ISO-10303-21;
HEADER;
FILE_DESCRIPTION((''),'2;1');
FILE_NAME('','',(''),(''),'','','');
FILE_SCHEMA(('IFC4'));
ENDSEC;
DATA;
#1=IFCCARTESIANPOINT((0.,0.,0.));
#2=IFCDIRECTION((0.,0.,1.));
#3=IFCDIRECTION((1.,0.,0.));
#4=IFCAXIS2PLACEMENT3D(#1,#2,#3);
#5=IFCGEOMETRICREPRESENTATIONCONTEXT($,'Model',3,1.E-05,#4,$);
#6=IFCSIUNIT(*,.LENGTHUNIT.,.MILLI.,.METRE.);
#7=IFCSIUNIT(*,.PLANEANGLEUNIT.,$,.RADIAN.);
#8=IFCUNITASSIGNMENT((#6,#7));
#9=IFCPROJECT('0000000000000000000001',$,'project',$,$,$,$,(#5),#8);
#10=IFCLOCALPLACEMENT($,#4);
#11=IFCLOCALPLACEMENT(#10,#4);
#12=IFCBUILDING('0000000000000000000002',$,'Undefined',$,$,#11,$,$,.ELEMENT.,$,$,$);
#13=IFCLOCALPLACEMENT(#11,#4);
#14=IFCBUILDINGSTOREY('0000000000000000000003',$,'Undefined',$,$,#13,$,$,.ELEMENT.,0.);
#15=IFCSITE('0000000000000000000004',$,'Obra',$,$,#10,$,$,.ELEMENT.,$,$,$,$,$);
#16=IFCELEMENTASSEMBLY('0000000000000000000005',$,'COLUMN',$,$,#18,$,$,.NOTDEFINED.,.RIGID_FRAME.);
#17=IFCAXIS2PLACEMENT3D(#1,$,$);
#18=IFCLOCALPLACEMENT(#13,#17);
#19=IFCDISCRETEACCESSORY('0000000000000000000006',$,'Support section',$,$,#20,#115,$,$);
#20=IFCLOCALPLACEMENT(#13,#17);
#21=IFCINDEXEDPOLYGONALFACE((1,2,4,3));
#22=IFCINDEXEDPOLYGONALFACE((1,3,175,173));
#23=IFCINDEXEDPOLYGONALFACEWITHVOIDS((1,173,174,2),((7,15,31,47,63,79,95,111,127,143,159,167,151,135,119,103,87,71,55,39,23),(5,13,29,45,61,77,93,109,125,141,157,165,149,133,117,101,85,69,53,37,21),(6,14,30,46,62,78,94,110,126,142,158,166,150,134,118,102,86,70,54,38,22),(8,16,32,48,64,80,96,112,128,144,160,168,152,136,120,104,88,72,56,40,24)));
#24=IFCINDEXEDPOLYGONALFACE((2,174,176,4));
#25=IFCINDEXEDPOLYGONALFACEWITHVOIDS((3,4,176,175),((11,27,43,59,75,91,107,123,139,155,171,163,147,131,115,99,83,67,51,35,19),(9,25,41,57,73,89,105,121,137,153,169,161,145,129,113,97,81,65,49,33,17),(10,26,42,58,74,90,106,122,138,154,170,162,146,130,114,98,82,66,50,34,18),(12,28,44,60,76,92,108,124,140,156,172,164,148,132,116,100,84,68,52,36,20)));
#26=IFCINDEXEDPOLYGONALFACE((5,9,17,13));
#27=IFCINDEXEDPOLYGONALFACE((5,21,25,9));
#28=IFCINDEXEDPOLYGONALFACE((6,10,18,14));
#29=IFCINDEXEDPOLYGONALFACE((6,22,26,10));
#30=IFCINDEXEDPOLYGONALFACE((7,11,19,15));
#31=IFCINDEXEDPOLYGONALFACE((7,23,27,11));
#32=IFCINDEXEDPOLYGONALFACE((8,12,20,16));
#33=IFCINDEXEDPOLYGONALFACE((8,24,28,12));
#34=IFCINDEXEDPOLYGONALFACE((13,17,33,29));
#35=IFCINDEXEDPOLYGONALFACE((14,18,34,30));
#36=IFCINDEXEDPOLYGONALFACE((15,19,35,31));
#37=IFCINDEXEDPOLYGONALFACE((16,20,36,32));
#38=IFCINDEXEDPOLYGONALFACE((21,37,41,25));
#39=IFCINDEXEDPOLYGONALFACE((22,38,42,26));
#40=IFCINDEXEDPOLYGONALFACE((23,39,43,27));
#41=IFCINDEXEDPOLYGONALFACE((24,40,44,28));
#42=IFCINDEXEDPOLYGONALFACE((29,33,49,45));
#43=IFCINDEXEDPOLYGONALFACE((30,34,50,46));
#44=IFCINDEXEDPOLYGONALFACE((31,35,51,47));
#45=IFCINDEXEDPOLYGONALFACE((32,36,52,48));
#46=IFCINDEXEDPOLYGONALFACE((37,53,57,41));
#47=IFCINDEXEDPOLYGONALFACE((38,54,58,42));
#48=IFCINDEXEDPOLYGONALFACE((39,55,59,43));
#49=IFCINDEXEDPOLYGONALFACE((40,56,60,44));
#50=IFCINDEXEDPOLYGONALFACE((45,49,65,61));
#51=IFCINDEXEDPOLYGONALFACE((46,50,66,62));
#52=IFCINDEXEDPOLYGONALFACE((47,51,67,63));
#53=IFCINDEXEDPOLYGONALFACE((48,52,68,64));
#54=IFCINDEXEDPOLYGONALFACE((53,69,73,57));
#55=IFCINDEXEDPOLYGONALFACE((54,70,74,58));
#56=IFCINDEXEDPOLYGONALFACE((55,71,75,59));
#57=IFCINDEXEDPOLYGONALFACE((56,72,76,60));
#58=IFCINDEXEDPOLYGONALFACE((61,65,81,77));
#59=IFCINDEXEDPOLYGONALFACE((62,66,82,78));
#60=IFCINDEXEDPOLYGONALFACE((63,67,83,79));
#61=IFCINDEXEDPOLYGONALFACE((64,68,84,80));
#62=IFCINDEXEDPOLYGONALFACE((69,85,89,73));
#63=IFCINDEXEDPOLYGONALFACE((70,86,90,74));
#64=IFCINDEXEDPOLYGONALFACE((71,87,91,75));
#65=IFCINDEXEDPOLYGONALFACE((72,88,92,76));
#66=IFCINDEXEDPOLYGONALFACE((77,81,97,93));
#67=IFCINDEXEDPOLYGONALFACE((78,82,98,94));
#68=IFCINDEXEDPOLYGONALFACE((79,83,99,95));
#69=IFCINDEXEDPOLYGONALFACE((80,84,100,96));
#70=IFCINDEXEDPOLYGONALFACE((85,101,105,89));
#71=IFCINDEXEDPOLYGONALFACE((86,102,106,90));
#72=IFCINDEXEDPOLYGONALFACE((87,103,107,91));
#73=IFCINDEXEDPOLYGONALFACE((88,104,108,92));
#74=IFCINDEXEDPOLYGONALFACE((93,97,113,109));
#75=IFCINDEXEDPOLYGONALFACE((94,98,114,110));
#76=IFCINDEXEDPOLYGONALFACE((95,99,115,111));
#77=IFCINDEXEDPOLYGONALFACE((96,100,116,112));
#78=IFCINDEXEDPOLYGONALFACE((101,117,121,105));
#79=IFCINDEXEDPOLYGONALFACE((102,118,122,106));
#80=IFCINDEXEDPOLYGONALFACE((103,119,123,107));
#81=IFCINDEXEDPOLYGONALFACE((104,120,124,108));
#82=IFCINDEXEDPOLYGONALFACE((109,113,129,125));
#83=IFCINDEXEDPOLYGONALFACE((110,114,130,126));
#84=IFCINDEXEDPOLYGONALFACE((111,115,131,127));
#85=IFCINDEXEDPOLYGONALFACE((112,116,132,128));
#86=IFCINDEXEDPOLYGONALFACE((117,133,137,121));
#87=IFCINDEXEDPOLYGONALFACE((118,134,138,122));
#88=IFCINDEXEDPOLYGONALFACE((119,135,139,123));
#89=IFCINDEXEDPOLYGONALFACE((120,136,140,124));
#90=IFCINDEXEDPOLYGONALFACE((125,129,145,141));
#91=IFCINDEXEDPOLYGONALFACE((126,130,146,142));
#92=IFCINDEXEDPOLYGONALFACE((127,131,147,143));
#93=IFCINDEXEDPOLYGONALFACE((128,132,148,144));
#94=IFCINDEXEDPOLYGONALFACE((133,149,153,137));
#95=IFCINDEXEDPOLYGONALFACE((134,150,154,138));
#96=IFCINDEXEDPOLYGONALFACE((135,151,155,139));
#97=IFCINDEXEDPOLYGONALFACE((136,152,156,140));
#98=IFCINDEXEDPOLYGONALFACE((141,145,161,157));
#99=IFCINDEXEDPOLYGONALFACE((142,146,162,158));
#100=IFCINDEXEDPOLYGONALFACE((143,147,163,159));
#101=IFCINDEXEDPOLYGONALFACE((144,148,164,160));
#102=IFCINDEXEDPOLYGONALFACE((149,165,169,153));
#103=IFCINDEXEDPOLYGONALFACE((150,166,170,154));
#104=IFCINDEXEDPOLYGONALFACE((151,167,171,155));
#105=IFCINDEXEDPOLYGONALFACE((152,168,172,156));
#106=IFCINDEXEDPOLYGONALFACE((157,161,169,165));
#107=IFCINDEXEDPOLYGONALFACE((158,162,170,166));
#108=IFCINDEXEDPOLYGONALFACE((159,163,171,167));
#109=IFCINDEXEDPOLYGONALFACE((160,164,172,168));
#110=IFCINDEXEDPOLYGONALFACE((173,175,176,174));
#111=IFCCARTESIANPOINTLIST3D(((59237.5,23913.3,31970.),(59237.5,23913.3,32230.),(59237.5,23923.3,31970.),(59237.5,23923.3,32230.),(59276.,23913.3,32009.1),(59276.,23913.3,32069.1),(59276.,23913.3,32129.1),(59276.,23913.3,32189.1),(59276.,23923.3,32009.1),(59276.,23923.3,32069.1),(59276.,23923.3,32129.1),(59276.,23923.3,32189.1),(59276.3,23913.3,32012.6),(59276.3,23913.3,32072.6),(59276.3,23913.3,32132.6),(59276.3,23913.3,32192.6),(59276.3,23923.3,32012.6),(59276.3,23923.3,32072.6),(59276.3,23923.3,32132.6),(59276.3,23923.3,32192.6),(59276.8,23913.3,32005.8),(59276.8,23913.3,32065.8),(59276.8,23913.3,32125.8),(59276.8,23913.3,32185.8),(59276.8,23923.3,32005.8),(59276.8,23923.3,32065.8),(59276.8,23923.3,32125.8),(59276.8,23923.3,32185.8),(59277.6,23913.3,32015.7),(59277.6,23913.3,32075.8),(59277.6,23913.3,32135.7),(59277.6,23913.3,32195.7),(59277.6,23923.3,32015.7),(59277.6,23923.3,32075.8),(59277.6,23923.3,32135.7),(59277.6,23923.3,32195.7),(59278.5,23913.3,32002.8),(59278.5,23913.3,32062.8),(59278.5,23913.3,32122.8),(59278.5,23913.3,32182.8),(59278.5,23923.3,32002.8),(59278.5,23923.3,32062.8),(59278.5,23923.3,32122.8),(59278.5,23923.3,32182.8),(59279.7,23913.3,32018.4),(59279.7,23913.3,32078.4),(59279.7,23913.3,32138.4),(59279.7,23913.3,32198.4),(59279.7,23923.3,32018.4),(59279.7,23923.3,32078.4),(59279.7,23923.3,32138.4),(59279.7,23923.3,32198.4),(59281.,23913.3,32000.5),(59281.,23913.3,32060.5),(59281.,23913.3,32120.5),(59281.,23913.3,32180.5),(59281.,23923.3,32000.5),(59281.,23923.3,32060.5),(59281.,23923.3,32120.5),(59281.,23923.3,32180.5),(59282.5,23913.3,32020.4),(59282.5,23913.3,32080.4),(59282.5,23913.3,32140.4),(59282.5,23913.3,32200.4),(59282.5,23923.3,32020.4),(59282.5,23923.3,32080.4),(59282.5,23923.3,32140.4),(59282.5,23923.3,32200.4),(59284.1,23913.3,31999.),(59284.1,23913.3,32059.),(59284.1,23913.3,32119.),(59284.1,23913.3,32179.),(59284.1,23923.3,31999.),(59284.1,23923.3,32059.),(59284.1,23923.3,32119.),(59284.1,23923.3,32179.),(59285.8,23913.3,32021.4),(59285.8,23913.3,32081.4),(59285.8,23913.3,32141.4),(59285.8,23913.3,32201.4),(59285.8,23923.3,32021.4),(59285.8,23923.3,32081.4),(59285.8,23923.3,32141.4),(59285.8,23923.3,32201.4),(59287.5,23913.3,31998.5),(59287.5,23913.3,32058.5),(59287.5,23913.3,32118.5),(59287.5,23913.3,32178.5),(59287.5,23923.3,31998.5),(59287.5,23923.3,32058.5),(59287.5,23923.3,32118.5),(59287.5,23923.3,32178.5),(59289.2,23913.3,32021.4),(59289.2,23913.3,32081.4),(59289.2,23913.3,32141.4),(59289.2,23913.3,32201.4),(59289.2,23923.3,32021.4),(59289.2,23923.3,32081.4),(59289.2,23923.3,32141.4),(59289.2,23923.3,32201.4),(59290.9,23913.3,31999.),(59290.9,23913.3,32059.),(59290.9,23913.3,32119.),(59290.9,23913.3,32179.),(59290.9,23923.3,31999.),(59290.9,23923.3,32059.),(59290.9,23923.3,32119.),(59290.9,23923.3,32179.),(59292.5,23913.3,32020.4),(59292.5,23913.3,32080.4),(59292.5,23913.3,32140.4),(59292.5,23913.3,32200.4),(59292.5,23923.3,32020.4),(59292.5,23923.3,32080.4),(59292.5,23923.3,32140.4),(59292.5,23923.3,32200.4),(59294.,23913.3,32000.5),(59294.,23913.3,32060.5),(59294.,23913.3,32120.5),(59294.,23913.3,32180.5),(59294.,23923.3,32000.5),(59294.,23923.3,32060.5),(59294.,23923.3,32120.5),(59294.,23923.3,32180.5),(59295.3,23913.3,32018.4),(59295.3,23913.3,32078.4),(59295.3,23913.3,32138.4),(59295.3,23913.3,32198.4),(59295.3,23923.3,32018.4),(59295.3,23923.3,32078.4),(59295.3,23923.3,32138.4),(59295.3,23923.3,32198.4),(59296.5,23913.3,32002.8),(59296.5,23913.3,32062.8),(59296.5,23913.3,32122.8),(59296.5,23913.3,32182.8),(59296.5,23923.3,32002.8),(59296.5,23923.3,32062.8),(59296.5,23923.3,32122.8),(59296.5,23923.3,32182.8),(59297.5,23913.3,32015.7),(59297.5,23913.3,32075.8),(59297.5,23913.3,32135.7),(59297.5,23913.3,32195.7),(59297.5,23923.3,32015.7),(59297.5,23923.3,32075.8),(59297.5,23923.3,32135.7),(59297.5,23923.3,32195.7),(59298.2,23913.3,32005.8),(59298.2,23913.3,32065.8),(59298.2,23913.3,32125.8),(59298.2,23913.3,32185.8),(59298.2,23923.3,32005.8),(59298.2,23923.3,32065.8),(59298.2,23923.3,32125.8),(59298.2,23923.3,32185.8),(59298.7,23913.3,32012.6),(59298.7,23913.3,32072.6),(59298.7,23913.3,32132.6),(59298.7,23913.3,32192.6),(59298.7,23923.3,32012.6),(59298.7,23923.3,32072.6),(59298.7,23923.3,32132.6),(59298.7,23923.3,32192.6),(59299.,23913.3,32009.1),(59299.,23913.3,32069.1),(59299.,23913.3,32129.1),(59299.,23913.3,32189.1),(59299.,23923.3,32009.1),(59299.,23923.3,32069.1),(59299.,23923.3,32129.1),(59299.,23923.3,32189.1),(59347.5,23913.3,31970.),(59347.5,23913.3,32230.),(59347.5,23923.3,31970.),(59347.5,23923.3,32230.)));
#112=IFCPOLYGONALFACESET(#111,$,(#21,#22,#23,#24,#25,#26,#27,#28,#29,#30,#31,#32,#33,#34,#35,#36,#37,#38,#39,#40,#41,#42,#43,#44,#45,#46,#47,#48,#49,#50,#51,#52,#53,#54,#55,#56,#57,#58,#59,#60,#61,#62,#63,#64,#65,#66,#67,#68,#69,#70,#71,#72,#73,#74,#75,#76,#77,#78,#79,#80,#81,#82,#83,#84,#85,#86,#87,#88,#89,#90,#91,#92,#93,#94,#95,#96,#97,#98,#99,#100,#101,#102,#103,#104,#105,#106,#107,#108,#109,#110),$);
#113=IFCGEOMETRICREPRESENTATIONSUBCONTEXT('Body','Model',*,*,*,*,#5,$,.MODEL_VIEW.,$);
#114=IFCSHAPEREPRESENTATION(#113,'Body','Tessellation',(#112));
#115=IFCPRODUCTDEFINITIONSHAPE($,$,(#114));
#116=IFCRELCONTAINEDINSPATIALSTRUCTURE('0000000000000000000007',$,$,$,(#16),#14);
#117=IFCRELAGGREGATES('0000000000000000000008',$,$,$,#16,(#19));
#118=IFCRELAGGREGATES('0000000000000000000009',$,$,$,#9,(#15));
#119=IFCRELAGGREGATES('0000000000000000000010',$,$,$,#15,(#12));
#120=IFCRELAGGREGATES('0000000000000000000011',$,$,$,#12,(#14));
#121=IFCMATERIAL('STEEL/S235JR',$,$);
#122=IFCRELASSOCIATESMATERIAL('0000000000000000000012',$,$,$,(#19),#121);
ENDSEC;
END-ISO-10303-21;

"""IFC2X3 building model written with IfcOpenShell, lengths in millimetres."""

from ifc_helpers import new_model, si_unit, frame, origin_with_axes, origin_2d_with_axis, place, context, subcontext, project, spatial, rectangle, circle, extrude, source, transform, mapped, material, element, aggregate, save


model = new_model("IFC2X3")

# Units and contexts
model_context = context("Model", 3, precision=1e-05, world=origin_with_axes())
body_context = subcontext(model_context, "Body", "Model", "MODEL_VIEW")
ifc_project = project(units=[si_unit("LENGTHUNIT", "METRE", prefix="MILLI"), si_unit("PLANEANGLEUNIT", "RADIAN")], contexts=[model_context])

# Site, building, storey
site_placement = place(None, origin_with_axes())
site = spatial("IfcSite", under=ifc_project, at=site_placement, Name="Obra", CompositionType="ELEMENT")
building_placement = place(site_placement, origin_with_axes())
building = spatial("IfcBuilding", under=site, at=building_placement, Name="Undefined", CompositionType="ELEMENT")
storey_placement = place(building_placement, origin_with_axes())
storey = spatial("IfcBuildingStorey", under=building, at=storey_placement, Name="Undefined", CompositionType="ELEMENT", Elevation=0.0)

# Element assembly
assembly_1_placement = place(storey_placement, origin_with_axes())
assembly_1 = element("IfcElementAssembly", 1, at=assembly_1_placement, inside=storey, Name="COLUMN", AssemblyPlace="NOTDEFINED", PredefinedType="RIGID_FRAME")
ifc_material_1 = material(Name="STEEL/S235JR")

# Discrete accessory, opening
shared_shape_1 = source(origin_with_axes(), body_context, "Body", "SweptSolid", [
    extrude(circle(Radius=11.5, at=origin_2d_with_axis()), frame((0.0, -14.4, 0.0), z_axis=(0.0, 1.0, 0.0), x_axis=(1.0, 0.0, 0.0)), (0.0, 0.0, 1.0), 10.2),
])
discrete_accessory_1_placement = place(assembly_1_placement, frame((59292.5, 23918.3, 31970.0), z_axis=(0.0, 0.0, 1.0), x_axis=(1.0, 0.0, 0.0)))
discrete_accessory_1 = element("IfcDiscreteAccessory", 2, at=discrete_accessory_1_placement, material=ifc_material_1, Name="Support section", context=body_context, shape_type="SweptSolid", body=[
    extrude(rectangle(XDim=10.0, YDim=110.0, at=origin_2d_with_axis()), frame((0.0, 0.0, 260.0), z_axis=(0.0, 0.0, -1.0), x_axis=(0.0, 1.0, 0.0)), (0.0, 0.0, 1.0), 260.0),
])
opening_1_placement = place(assembly_1_placement, frame((59337.5, 23909.0, 32300.0), z_axis=(-1.0, 0.0, 0.0), x_axis=(0.0, 0.0, -1.0)))
element("IfcOpeningElement", 3, at=opening_1_placement, cuts=discrete_accessory_1, ObjectType="Opening", context=body_context, shape_type="MappedRepresentation", body=[
    mapped(shared_shape_1, transform((110.0, 0.0, 50.0))),
    mapped(shared_shape_1, transform((170.0, 0.0, 50.0))),
    mapped(shared_shape_1, transform((230.0, 0.0, 50.0))),
    mapped(shared_shape_1, transform((290.0, 0.0, 50.0))),
])
aggregate(assembly_1, [discrete_accessory_1])

save(model, "model.ifc")
